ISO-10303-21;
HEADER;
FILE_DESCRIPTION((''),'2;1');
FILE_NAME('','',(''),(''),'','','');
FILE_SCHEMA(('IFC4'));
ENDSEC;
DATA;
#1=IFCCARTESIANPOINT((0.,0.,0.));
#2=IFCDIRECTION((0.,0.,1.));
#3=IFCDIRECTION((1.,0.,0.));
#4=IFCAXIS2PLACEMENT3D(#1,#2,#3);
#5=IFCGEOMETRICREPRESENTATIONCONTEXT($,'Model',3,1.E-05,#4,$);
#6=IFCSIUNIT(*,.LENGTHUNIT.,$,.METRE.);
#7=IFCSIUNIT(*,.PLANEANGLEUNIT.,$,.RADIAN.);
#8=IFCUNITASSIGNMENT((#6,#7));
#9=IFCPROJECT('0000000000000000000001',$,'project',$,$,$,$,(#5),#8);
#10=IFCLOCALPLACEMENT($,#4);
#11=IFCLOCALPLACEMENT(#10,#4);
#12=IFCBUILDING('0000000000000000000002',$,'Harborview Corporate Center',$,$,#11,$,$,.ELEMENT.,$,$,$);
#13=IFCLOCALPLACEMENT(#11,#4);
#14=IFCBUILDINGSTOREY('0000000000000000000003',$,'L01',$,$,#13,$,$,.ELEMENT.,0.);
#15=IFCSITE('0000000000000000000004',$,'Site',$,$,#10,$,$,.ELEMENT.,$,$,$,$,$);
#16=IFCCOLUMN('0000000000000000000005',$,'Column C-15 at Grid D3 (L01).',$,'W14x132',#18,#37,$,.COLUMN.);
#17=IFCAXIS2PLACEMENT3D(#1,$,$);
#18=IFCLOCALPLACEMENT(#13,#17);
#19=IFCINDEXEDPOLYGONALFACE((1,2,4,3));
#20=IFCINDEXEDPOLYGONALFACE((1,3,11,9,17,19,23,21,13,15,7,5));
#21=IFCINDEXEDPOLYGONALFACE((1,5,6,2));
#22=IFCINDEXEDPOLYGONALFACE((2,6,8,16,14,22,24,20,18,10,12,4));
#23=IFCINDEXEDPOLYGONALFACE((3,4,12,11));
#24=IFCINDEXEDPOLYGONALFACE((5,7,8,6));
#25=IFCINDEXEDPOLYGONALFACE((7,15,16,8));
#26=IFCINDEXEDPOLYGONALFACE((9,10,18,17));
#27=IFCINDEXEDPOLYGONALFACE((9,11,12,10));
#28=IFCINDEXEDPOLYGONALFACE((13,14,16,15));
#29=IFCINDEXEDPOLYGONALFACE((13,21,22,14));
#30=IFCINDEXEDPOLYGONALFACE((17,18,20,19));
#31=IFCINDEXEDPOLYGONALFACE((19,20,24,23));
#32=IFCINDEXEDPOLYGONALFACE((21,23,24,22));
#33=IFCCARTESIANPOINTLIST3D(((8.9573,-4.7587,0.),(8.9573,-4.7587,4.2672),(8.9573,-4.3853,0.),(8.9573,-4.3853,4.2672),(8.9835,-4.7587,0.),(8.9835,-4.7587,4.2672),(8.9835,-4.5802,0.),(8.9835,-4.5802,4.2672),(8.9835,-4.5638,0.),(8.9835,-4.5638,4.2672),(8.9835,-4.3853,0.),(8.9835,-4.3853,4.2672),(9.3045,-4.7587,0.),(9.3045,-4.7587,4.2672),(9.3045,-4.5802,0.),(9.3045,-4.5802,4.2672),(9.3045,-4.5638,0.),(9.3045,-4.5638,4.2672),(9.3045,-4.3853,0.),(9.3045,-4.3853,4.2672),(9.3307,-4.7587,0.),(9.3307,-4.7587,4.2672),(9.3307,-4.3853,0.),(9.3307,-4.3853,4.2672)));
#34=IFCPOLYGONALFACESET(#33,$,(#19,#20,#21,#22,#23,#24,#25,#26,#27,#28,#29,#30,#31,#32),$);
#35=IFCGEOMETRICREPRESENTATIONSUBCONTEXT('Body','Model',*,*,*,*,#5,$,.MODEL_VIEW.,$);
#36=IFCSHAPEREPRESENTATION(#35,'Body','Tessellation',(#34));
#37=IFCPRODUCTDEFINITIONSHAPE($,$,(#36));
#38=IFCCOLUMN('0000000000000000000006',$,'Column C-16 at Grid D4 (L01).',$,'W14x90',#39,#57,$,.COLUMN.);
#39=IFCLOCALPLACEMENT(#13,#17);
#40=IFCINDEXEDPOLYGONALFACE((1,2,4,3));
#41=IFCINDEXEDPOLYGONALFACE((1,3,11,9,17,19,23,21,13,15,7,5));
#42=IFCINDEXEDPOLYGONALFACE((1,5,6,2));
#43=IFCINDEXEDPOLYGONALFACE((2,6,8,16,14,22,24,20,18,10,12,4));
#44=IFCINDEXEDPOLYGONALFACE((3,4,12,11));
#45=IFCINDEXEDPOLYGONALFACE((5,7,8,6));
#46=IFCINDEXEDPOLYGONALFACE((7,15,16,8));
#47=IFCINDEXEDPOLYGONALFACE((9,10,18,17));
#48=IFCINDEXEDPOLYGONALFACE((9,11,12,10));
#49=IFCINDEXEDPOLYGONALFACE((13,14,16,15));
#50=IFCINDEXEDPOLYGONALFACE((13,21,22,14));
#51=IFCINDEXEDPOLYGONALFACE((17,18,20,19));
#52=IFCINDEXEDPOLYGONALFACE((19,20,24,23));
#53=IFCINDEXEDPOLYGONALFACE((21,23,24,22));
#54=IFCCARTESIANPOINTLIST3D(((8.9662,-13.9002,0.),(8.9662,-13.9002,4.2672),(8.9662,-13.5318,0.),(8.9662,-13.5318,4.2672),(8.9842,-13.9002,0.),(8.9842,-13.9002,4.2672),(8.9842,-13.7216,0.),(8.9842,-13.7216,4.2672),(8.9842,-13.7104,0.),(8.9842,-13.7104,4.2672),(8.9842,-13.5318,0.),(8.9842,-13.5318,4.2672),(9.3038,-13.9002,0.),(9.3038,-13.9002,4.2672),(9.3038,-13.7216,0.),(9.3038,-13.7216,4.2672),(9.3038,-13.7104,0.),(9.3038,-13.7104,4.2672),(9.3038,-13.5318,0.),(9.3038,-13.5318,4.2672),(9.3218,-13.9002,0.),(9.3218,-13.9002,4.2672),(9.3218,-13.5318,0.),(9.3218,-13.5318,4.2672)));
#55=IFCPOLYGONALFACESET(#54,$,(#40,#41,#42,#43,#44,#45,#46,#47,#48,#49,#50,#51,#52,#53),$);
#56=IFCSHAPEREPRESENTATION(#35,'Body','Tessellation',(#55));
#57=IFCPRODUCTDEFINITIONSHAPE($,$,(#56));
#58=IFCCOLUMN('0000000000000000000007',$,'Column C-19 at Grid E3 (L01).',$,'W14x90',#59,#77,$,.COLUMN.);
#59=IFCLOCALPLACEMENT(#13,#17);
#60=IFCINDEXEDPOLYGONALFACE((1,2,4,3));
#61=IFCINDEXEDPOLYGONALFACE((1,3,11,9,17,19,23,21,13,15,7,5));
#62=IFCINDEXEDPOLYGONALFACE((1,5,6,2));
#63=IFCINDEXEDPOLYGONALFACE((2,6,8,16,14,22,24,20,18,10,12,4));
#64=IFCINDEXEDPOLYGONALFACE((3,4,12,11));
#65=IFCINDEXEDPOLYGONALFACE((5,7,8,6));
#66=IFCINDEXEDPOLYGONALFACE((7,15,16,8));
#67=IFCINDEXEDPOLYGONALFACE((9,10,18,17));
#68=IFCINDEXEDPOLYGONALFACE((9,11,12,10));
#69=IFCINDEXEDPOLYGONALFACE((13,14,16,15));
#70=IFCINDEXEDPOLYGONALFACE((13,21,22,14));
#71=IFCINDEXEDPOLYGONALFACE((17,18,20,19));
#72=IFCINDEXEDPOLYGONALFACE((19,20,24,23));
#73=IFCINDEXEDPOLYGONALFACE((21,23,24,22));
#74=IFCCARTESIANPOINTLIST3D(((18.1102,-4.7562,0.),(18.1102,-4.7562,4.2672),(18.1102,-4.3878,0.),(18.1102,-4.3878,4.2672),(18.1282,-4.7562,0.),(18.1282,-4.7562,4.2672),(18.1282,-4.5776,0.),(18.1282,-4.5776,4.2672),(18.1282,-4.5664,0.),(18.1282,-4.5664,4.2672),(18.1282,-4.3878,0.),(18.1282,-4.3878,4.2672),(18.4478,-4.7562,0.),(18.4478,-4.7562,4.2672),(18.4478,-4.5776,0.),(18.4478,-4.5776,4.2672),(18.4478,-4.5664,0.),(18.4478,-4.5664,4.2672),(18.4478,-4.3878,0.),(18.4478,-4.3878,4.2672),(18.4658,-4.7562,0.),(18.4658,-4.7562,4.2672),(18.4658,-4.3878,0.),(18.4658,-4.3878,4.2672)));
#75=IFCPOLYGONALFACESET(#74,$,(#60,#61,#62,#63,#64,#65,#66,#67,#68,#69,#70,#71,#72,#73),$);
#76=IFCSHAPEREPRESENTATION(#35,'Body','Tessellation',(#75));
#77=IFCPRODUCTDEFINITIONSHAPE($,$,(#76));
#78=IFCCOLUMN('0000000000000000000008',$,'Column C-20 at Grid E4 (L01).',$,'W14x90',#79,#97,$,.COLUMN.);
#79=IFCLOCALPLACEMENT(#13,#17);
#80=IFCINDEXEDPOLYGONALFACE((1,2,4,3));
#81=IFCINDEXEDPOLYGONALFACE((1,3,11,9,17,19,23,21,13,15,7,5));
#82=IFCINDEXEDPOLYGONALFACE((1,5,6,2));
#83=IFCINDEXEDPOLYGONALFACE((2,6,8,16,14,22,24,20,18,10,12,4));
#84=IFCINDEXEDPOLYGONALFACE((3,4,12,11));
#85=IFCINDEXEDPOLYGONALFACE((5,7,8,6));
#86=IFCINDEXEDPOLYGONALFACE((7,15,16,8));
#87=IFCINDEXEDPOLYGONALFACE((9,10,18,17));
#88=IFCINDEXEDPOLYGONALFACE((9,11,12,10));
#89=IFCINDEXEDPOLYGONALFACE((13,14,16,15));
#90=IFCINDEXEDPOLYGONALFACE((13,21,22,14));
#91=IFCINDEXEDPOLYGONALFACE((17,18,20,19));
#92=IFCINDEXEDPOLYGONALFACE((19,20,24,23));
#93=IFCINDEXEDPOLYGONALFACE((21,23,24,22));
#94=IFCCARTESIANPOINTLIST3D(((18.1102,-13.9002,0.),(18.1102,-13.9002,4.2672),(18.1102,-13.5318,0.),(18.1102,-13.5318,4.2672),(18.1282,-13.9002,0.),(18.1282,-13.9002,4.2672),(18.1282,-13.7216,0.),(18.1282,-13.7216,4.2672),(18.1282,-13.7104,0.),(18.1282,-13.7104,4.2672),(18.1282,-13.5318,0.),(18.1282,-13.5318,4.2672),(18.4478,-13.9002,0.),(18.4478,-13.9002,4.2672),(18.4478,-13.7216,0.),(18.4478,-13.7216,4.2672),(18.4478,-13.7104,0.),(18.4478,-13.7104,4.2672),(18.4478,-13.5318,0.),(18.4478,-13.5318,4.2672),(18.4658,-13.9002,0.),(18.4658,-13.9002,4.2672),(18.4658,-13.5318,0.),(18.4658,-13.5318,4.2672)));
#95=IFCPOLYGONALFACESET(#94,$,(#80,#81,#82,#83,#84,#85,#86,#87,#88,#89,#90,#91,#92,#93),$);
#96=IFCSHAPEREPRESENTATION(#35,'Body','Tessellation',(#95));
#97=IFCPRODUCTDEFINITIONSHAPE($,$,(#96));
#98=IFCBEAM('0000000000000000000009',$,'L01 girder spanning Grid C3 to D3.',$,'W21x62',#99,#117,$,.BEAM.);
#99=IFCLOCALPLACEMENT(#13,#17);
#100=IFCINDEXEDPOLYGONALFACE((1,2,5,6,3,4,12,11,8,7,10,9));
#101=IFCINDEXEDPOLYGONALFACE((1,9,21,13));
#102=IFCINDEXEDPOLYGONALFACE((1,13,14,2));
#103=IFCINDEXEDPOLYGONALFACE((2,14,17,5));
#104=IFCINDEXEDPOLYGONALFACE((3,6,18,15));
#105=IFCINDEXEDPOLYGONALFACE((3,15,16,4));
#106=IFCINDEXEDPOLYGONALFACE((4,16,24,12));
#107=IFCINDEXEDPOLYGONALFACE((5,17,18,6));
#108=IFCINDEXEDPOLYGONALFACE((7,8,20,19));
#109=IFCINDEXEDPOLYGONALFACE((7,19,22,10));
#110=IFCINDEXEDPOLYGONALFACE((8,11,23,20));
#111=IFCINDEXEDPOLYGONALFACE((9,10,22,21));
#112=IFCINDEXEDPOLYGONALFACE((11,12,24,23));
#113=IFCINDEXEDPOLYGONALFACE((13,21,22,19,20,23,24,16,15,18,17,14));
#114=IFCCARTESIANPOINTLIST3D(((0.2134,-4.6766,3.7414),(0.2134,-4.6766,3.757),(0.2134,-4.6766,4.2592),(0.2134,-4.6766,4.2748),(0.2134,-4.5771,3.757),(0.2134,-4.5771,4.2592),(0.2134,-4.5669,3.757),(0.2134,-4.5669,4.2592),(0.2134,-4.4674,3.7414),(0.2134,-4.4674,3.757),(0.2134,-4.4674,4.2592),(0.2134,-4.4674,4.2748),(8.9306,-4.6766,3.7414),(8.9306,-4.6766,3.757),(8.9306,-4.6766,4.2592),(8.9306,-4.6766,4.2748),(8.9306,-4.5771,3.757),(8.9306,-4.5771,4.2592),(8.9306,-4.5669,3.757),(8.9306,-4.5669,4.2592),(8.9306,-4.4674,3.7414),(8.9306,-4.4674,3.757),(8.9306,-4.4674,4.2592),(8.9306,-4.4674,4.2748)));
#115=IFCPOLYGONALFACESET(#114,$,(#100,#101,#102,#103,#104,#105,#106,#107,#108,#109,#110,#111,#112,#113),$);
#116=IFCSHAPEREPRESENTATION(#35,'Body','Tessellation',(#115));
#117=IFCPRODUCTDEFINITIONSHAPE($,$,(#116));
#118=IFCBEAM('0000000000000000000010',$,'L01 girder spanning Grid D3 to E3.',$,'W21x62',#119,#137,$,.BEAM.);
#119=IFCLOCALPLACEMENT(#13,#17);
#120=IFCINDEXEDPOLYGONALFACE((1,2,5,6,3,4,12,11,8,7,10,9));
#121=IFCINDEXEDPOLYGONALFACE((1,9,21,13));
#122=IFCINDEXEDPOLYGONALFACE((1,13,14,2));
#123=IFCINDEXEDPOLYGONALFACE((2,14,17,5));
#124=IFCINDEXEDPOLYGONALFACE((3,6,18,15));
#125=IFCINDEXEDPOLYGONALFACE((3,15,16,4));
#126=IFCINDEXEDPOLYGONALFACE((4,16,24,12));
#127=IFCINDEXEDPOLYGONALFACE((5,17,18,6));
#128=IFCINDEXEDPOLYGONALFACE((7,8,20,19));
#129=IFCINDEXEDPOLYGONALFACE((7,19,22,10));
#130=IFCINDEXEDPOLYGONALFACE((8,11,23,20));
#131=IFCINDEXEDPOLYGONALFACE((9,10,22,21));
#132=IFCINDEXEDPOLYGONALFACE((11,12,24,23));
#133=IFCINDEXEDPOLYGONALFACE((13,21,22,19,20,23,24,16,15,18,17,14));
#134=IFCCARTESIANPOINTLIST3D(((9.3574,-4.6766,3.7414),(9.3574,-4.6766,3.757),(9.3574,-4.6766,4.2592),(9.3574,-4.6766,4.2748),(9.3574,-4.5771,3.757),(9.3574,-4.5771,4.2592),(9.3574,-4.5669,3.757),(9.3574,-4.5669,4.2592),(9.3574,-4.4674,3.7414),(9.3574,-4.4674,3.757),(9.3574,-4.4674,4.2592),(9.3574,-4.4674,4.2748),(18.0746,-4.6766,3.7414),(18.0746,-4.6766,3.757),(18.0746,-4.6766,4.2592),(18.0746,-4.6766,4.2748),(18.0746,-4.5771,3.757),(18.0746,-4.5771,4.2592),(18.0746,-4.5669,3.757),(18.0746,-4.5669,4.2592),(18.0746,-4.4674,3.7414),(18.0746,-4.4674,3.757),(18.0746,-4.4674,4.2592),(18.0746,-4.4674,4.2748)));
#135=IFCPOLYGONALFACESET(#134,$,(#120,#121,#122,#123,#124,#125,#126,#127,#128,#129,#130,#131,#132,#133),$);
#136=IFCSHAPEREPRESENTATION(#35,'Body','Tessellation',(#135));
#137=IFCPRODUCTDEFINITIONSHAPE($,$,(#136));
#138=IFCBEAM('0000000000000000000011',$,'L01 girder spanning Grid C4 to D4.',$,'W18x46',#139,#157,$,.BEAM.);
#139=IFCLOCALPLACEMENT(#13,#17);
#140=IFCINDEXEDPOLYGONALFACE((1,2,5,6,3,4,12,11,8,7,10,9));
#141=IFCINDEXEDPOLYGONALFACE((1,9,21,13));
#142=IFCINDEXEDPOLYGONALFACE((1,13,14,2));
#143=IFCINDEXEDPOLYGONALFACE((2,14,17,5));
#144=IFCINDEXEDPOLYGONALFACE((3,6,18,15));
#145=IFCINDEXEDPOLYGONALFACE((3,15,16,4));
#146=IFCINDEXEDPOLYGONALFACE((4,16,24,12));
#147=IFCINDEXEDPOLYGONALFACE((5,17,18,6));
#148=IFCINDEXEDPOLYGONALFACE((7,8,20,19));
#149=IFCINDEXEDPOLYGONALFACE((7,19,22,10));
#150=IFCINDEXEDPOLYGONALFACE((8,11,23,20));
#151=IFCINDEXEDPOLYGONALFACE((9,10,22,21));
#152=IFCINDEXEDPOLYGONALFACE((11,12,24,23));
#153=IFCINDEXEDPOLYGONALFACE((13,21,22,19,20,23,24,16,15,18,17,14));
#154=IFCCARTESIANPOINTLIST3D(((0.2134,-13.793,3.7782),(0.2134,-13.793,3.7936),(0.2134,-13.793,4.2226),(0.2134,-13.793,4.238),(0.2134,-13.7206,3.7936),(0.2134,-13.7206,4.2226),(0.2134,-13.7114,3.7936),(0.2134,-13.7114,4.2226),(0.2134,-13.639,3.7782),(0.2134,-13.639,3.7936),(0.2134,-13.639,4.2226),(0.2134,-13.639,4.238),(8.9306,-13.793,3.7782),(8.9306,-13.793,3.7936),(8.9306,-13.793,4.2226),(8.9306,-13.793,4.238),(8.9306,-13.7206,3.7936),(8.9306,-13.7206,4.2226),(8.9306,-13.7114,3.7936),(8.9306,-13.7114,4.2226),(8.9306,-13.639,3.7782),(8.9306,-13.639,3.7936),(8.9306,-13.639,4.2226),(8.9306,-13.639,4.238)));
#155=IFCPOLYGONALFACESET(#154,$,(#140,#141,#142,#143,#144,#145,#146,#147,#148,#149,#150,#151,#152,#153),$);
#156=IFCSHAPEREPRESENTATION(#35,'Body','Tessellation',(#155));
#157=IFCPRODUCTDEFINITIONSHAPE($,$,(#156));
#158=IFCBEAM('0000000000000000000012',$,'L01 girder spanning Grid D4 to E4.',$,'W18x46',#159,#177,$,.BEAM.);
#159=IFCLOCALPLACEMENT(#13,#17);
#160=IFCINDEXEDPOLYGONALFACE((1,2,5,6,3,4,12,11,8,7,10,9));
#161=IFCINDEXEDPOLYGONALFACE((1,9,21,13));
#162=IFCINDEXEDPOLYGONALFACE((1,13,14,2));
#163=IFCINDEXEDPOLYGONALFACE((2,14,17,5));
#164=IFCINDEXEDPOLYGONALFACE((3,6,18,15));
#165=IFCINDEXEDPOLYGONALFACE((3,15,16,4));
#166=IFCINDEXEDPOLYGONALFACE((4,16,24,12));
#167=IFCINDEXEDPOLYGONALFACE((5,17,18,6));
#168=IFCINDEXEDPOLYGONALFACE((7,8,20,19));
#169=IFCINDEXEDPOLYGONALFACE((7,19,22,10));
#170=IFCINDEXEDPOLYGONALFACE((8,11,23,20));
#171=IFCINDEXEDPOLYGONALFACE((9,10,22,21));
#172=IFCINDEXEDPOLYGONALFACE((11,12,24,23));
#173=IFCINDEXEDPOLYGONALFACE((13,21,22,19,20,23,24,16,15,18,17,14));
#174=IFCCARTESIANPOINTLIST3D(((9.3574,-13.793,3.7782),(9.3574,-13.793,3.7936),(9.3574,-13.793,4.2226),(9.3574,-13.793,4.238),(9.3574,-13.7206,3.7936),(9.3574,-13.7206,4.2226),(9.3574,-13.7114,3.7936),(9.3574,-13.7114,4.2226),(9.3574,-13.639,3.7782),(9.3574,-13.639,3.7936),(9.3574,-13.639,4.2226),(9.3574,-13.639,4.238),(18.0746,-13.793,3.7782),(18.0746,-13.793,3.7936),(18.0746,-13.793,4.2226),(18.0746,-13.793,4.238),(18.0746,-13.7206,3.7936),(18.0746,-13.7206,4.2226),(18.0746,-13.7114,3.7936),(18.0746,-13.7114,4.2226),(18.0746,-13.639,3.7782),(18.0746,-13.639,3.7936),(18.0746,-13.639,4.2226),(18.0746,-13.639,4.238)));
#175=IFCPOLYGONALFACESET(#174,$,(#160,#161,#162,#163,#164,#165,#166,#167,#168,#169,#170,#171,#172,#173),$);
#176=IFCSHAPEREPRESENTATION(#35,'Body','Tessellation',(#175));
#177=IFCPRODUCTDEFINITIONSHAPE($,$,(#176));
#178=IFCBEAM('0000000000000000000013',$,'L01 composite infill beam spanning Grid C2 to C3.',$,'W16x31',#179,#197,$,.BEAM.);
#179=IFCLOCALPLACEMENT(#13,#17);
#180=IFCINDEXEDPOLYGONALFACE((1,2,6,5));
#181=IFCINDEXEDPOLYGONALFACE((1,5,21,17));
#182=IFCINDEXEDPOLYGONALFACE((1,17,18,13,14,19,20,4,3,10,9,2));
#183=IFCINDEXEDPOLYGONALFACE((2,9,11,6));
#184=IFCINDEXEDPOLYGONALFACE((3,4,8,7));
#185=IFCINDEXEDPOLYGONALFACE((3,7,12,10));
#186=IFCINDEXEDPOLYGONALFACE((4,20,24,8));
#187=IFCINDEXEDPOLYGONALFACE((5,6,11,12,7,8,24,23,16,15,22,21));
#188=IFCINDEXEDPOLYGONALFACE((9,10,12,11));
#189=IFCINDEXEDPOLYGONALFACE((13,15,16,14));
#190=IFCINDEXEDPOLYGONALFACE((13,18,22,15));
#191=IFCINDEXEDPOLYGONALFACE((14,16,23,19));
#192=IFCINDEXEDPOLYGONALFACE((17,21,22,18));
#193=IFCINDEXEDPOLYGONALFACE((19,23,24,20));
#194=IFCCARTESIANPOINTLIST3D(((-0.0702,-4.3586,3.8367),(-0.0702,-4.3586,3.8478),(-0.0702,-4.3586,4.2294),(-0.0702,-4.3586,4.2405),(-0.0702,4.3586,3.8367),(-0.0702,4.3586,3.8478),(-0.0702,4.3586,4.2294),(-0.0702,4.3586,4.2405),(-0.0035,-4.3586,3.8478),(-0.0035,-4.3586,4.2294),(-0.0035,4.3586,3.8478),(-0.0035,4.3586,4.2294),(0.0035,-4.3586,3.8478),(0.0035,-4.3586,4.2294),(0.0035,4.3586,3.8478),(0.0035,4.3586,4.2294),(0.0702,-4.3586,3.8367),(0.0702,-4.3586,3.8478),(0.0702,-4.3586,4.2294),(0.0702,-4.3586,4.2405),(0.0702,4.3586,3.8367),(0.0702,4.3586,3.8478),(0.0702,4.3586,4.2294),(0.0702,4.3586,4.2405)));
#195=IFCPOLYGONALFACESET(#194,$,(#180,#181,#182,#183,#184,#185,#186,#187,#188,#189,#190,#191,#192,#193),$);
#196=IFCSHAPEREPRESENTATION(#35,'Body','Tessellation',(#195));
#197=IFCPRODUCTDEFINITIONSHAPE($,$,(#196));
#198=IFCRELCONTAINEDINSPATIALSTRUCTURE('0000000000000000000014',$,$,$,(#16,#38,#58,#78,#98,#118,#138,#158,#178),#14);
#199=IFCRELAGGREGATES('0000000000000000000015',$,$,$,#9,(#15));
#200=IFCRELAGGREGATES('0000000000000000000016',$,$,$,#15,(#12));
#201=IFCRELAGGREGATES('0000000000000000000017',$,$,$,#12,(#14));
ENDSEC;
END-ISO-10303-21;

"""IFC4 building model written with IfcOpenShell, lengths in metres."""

from ifc_helpers import new_model, si_unit, frame, origin_with_axes, place, context, subcontext, project, spatial, i_section, extrude, element, save


model = new_model("IFC4")

# Units and contexts
model_context = context("Model", 3, precision=1e-05, world=origin_with_axes())
body_context = subcontext(model_context, "Body", "Model", "MODEL_VIEW")
ifc_project = project(units=[si_unit("LENGTHUNIT", "METRE"), si_unit("PLANEANGLEUNIT", "RADIAN")], contexts=[model_context])

# Site, building, storey
site_placement = place(None, origin_with_axes())
site = spatial("IfcSite", under=ifc_project, at=site_placement, Name="Site", CompositionType="ELEMENT")
building_placement = place(site_placement, origin_with_axes())
building = spatial("IfcBuilding", under=site, at=building_placement, Name="Harborview Corporate Center", CompositionType="ELEMENT")
storey_placement = place(building_placement, origin_with_axes())
storey = spatial("IfcBuildingStorey", under=building, at=storey_placement, Name="L01", CompositionType="ELEMENT", Elevation=0.0)

# Columns
column_placement = place(storey_placement, frame((9.144, -4.572, 0.0), z_axis=(0.0, 0.0, 1.0), x_axis=(0.0, 1.0, 0.0)))
element("IfcColumn", 1, at=column_placement, inside=storey, Name="Column C-15 at Grid D3 (L01).", ObjectType="W14x132", PredefinedType="COLUMN", context=body_context, shape_type="SweptSolid", body=[
    extrude(i_section(OverallWidth=0.3734, OverallDepth=0.3734, WebThickness=0.0164, FlangeThickness=0.0262), origin_with_axes(), (0.0, 0.0, 1.0), 4.2672),
])
for number, where, z_axis, x_axis, name in (
    (2, (9.144, -13.716, 0.0), (0.0, 0.0, 1.0), (0.0, 1.0, 0.0), "Column C-16 at Grid D4 (L01)."),
    (3, (18.288, -4.572, 0.0), (0.0, 0.0, 1.0), (0.0, 1.0, 0.0), "Column C-19 at Grid E3 (L01)."),
    (4, (18.288, -13.716, 0.0), (0.0, 0.0, 1.0), (0.0, 1.0, 0.0), "Column C-20 at Grid E4 (L01)."),
):
    element("IfcColumn", number, at=place(storey_placement, frame(where, z_axis=z_axis, x_axis=x_axis)), inside=storey, Name=name, ObjectType="W14x90", PredefinedType="COLUMN", context=body_context, shape_type="SweptSolid", body=[
        extrude(i_section(OverallWidth=0.3683, OverallDepth=0.3556, WebThickness=0.0112, FlangeThickness=0.018), origin_with_axes(), (0.0, 0.0, 1.0), 4.2672),
    ])

# Beams
beam_1_placement = place(storey_placement, frame((0.2134, -4.572, 4.0081), z_axis=(1.0, 0.0, 0.0), x_axis=(0.0, 1.0, 0.0)))
element("IfcBeam", 5, at=beam_1_placement, inside=storey, Name="L01 girder spanning Grid C3 to D3.", ObjectType="W21x62", PredefinedType="BEAM", context=body_context, shape_type="SweptSolid", body=[
    extrude(i_section(OverallWidth=0.2093, OverallDepth=0.5334, WebThickness=0.0102, FlangeThickness=0.0156), origin_with_axes(), (0.0, 0.0, 1.0), 8.7173),
])
beam_2_placement = place(storey_placement, frame((9.3574, -4.572, 4.0081), z_axis=(1.0, 0.0, 0.0), x_axis=(0.0, 1.0, 0.0)))
element("IfcBeam", 6, at=beam_2_placement, inside=storey, Name="L01 girder spanning Grid D3 to E3.", ObjectType="W21x62", PredefinedType="BEAM", context=body_context, shape_type="SweptSolid", body=[
    extrude(i_section(OverallWidth=0.2093, OverallDepth=0.5334, WebThickness=0.0102, FlangeThickness=0.0156), origin_with_axes(), (0.0, 0.0, 1.0), 8.7173),
])
beam_3_placement = place(storey_placement, frame((0.2134, -13.716, 4.0081), z_axis=(1.0, 0.0, 0.0), x_axis=(0.0, 1.0, 0.0)))
element("IfcBeam", 7, at=beam_3_placement, inside=storey, Name="L01 girder spanning Grid C4 to D4.", ObjectType="W18x46", PredefinedType="BEAM", context=body_context, shape_type="SweptSolid", body=[
    extrude(i_section(OverallWidth=0.1539, OverallDepth=0.4597, WebThickness=0.0091, FlangeThickness=0.0154), origin_with_axes(), (0.0, 0.0, 1.0), 8.7173),
])
beam_4_placement = place(storey_placement, frame((9.3574, -13.716, 4.0081), z_axis=(1.0, 0.0, 0.0), x_axis=(0.0, 1.0, 0.0)))
element("IfcBeam", 8, at=beam_4_placement, inside=storey, Name="L01 girder spanning Grid D4 to E4.", ObjectType="W18x46", PredefinedType="BEAM", context=body_context, shape_type="SweptSolid", body=[
    extrude(i_section(OverallWidth=0.1539, OverallDepth=0.4597, WebThickness=0.0091, FlangeThickness=0.0154), origin_with_axes(), (0.0, 0.0, 1.0), 8.7173),
])
beam_5_placement = place(storey_placement, frame((0.0, -4.3586, 4.0386), z_axis=(0.0, 1.0, 0.0), x_axis=(-1.0, 0.0, 0.0)))
element("IfcBeam", 9, at=beam_5_placement, inside=storey, Name="L01 composite infill beam spanning Grid C2 to C3.", ObjectType="W16x31", PredefinedType="BEAM", context=body_context, shape_type="SweptSolid", body=[
    extrude(i_section(OverallWidth=0.1405, OverallDepth=0.4039, WebThickness=0.007, FlangeThickness=0.0112), origin_with_axes(), (0.0, 0.0, 1.0), 8.7173),
])

save(model, "model.ifc")
